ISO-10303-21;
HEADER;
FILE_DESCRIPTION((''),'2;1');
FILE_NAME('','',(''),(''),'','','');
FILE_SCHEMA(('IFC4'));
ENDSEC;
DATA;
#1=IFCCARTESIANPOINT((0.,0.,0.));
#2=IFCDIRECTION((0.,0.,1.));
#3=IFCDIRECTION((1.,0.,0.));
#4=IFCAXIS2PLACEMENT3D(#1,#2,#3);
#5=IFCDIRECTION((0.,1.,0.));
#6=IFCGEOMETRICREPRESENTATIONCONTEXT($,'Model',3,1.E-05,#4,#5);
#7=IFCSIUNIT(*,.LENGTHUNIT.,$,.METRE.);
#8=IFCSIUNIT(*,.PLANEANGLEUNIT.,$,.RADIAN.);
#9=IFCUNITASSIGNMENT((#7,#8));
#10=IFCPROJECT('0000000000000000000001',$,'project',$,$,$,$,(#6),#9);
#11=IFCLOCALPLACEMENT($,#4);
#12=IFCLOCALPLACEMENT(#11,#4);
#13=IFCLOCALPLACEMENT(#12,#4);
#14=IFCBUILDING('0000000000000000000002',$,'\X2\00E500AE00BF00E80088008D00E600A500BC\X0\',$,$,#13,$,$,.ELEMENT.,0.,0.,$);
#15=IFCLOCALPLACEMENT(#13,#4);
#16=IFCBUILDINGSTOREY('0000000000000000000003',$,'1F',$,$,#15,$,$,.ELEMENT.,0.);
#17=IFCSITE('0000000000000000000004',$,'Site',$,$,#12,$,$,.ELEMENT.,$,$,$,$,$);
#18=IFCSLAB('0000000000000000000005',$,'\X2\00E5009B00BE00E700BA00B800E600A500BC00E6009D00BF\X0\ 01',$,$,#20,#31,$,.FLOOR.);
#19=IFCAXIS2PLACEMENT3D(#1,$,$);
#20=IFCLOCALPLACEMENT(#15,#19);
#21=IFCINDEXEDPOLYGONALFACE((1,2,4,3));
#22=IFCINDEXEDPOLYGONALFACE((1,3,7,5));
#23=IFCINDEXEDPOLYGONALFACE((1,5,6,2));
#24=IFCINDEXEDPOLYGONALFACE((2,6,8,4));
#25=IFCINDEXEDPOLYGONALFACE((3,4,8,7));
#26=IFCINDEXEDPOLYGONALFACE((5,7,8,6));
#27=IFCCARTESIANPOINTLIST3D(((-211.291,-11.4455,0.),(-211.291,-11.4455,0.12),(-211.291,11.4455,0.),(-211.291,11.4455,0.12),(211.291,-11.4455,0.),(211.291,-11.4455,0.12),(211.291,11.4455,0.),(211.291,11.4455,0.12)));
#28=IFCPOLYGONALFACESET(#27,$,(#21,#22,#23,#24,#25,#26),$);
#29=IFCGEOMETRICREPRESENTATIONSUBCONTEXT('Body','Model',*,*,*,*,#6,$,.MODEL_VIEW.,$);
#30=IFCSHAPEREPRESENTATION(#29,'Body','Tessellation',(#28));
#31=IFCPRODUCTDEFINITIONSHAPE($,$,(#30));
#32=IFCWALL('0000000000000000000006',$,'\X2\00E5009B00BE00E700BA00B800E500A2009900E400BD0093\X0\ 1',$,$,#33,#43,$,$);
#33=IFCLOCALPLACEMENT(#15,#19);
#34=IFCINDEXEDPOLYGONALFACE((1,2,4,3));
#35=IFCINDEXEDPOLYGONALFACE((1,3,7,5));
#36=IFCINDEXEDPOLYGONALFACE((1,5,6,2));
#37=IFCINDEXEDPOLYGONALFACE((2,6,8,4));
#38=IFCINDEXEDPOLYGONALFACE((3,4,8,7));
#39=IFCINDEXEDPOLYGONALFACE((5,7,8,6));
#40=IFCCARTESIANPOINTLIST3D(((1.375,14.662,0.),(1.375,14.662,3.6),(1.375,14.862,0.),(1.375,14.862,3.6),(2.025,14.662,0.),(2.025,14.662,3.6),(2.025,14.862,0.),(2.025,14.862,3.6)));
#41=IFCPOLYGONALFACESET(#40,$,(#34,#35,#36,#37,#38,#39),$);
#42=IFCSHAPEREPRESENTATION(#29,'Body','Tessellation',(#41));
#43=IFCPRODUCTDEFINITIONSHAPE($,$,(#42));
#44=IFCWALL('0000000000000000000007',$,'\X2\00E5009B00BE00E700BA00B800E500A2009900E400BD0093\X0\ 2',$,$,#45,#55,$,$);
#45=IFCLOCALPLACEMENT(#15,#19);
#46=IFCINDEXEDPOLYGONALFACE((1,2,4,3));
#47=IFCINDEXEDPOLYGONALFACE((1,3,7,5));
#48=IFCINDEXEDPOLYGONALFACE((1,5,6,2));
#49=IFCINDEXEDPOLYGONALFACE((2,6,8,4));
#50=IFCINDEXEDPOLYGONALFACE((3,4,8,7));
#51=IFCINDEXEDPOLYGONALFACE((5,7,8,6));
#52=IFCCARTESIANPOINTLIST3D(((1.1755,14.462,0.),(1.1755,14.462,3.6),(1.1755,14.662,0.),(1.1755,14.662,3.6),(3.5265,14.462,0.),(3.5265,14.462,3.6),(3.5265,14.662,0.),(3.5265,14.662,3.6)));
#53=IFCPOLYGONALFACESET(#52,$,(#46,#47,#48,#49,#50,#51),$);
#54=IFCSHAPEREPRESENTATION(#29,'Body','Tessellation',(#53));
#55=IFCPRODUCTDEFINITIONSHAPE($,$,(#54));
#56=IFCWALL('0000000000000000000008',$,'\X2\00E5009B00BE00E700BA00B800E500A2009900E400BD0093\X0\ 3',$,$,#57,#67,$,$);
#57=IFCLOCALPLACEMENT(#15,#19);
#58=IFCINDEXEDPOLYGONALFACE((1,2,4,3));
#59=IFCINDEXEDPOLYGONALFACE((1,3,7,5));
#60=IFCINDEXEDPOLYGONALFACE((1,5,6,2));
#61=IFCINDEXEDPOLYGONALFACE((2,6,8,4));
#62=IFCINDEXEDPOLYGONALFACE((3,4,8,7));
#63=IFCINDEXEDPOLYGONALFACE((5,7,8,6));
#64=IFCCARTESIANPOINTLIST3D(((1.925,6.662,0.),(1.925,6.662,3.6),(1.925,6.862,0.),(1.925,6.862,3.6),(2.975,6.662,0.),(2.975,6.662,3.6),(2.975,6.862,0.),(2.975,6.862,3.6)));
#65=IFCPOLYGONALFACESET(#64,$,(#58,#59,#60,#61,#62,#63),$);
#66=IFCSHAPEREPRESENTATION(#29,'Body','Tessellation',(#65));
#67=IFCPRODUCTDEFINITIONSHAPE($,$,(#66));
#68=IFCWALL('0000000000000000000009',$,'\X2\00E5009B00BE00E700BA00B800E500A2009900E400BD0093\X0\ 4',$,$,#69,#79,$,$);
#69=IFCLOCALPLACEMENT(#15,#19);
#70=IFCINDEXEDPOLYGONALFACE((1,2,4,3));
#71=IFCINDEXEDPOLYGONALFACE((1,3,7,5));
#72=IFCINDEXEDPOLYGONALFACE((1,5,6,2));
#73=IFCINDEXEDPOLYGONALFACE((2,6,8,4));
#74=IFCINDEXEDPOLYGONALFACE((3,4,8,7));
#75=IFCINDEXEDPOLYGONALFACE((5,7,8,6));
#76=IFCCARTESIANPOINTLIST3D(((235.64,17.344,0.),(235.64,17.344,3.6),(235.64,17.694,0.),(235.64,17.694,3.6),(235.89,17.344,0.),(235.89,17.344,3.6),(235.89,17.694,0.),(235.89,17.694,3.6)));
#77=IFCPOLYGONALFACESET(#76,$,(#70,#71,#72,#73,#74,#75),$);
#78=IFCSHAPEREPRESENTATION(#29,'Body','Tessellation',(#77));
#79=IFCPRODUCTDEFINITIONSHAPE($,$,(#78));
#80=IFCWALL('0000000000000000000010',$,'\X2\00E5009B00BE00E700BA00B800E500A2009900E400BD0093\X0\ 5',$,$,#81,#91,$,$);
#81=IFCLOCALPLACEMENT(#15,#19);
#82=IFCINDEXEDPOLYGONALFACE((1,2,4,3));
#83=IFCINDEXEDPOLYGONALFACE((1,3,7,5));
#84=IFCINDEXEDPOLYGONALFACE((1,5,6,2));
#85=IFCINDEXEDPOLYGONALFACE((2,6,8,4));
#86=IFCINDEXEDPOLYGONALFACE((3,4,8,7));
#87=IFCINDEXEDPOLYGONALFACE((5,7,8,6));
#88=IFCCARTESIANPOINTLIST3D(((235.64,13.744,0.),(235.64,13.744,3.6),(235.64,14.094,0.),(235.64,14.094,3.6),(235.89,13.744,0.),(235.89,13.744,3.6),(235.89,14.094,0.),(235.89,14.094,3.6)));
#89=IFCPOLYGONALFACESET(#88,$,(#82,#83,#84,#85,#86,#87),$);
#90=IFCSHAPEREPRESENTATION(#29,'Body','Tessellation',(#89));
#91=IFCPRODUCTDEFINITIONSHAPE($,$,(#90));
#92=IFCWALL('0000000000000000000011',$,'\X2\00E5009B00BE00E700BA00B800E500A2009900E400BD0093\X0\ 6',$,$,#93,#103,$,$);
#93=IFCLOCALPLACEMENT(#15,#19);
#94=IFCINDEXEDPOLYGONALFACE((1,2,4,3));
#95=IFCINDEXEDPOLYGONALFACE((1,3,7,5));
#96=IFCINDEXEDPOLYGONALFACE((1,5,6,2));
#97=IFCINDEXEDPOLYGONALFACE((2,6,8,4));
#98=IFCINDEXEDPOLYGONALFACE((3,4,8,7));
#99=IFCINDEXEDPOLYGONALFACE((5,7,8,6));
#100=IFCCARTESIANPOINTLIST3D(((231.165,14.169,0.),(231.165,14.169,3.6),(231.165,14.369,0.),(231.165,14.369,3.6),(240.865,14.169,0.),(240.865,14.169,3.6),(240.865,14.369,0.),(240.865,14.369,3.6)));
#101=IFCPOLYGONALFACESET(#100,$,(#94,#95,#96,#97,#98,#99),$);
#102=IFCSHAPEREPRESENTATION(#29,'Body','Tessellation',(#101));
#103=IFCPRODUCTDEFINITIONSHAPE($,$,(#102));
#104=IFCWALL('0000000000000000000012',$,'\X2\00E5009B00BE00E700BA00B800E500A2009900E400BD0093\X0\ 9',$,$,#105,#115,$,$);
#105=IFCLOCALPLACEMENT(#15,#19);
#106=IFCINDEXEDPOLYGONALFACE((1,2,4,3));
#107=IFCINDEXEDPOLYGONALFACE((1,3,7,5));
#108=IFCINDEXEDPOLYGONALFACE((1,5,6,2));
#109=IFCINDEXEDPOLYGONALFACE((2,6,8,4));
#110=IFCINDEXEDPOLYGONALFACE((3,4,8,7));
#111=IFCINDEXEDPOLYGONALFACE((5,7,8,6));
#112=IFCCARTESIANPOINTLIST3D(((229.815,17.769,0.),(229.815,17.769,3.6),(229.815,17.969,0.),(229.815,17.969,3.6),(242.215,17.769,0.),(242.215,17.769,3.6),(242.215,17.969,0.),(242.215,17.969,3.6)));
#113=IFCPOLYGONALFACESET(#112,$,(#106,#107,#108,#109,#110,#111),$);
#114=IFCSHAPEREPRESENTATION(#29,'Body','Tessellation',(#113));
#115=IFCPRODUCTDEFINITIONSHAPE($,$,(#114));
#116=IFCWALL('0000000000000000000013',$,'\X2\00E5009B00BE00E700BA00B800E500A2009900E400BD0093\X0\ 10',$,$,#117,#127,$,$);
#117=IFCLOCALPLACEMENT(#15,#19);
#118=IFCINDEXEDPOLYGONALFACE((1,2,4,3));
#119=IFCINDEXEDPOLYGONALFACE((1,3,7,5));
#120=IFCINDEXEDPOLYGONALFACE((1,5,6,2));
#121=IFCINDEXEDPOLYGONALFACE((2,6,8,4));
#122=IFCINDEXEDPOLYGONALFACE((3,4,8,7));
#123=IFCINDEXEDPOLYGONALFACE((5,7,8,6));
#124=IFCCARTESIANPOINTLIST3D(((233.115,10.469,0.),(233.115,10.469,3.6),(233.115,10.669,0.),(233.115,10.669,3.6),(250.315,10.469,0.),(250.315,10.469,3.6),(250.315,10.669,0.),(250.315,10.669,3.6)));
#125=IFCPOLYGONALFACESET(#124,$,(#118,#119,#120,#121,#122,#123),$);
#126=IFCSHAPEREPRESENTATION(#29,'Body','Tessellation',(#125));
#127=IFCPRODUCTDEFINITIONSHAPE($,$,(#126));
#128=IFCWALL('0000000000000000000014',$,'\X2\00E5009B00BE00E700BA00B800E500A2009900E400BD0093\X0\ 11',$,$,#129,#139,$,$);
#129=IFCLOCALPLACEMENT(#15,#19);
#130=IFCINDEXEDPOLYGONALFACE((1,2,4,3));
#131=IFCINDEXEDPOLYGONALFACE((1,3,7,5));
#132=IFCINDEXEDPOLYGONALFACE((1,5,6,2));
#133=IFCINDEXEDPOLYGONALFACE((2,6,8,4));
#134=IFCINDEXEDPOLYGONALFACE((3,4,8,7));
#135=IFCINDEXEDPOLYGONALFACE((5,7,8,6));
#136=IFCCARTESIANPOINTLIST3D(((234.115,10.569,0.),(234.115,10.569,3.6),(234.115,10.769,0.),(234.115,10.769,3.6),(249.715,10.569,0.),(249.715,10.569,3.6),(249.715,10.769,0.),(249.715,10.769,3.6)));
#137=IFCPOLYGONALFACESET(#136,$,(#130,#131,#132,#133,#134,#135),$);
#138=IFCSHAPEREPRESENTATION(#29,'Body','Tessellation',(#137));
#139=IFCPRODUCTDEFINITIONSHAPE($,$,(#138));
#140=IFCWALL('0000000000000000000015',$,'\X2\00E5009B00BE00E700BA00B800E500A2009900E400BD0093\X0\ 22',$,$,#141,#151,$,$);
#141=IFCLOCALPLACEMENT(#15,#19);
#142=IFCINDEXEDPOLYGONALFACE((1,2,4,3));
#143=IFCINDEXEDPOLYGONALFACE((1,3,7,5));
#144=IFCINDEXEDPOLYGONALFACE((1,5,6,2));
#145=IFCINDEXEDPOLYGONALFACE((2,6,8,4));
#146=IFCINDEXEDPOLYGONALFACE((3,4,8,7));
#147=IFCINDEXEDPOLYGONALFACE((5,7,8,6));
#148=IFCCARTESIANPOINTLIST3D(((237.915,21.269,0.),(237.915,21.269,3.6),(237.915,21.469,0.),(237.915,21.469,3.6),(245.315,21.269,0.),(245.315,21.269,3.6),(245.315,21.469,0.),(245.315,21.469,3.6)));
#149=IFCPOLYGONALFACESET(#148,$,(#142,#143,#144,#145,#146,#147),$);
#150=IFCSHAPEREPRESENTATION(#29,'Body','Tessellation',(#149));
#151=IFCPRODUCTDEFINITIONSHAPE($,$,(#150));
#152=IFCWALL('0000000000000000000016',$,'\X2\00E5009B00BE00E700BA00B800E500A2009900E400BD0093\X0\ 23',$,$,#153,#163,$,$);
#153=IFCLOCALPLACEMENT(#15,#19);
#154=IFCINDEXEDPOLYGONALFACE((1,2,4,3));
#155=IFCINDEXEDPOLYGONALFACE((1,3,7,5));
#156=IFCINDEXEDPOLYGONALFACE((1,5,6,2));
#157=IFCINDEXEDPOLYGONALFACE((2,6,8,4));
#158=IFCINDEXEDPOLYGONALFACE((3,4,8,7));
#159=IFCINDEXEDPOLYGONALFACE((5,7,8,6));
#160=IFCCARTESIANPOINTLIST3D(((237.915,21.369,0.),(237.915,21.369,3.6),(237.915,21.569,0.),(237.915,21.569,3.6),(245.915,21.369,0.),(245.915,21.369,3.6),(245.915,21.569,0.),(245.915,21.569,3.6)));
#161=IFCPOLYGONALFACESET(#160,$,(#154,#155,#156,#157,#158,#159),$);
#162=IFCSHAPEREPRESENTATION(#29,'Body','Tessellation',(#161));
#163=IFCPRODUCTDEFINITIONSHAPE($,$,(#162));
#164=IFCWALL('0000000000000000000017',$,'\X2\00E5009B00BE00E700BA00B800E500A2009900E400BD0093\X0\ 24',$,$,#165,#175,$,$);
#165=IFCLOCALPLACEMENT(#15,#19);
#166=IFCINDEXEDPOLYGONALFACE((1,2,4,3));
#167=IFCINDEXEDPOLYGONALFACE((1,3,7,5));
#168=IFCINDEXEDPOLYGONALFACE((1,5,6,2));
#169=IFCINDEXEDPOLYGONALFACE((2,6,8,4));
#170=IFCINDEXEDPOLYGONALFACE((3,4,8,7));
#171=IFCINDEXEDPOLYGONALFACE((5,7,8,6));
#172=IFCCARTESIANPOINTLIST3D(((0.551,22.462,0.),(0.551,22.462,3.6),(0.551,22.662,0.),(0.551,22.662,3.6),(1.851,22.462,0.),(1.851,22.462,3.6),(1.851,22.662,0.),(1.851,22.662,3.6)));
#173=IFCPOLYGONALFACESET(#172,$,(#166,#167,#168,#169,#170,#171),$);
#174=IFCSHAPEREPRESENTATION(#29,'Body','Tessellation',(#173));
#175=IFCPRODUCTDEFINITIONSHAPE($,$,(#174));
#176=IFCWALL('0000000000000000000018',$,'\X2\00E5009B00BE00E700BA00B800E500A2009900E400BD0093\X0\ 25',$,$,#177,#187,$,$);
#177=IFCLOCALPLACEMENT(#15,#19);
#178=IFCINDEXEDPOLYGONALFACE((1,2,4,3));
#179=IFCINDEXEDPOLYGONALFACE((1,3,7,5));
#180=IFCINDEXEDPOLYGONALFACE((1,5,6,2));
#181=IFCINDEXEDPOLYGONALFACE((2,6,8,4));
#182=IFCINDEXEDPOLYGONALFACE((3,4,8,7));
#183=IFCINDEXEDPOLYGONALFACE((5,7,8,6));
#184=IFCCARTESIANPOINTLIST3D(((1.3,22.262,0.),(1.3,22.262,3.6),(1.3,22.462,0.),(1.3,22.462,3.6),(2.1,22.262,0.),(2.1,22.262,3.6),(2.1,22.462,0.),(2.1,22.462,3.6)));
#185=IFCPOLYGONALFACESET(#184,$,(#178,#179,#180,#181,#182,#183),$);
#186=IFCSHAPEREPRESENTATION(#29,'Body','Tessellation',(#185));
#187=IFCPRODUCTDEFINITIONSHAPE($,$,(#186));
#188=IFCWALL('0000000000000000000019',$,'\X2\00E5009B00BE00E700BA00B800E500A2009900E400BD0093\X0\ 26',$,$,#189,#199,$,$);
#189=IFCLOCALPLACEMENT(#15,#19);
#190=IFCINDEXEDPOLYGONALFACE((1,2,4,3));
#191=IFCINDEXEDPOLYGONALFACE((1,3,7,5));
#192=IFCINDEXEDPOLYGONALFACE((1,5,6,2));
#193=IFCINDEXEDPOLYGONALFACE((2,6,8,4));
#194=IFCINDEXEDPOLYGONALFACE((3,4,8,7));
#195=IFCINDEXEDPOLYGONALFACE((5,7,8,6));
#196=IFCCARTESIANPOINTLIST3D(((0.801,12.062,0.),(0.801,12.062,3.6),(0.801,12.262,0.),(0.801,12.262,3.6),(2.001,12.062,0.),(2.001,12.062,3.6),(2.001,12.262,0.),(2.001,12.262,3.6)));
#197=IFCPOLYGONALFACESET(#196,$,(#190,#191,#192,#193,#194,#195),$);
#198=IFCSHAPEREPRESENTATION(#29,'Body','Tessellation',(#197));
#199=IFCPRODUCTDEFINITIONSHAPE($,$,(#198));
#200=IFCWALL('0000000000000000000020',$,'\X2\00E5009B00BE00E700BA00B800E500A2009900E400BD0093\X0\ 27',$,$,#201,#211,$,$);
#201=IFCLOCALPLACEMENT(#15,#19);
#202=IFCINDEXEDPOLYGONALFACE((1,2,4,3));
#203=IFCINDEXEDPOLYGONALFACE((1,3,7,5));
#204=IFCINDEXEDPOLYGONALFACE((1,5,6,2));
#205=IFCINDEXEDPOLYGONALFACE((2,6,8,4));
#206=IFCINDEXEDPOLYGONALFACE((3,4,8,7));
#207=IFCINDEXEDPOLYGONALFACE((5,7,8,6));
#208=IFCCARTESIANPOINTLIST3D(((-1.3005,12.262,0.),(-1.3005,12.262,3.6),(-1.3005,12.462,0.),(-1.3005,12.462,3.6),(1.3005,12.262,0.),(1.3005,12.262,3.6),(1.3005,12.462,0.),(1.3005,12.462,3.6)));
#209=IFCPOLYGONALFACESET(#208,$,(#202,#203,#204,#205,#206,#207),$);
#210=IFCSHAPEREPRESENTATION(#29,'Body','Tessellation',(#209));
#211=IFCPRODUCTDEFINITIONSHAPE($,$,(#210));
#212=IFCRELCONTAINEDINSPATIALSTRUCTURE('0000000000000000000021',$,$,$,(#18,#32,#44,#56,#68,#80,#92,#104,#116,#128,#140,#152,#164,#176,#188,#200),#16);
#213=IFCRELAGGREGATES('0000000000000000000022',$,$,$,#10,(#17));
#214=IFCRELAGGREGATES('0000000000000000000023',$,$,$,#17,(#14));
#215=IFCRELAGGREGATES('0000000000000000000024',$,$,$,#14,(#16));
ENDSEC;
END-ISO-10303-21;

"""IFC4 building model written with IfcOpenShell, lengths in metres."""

from ifc_helpers import new_model, si_unit, direction, frame, frame_2d, origin_with_axes, place, context, subcontext, project, spatial, rectangle, extrude, element, save


model = new_model("IFC4")

# Units and contexts
model_context = context("Model", 3, precision=1e-05, world=origin_with_axes(), true_north=direction((0.0, 1.0, 0.0)))
body_context = subcontext(model_context, "Body", "Model", "MODEL_VIEW")
ifc_project = project(units=[si_unit("LENGTHUNIT", "METRE"), si_unit("PLANEANGLEUNIT", "RADIAN")], contexts=[model_context])

# Site, building, storey
placement = place(None, origin_with_axes())
site_placement = place(placement, origin_with_axes())
site = spatial("IfcSite", under=ifc_project, at=site_placement, Name="Site", CompositionType="ELEMENT")
building_placement = place(site_placement, origin_with_axes())
building = spatial("IfcBuilding", under=site, at=building_placement, Name="å®¿è\u0088\u008dæ¥¼", CompositionType="ELEMENT", ElevationOfRefHeight=0.0, ElevationOfTerrain=0.0)
storey_placement = place(building_placement, origin_with_axes())
storey = spatial("IfcBuildingStorey", under=building, at=storey_placement, Name="1F", CompositionType="ELEMENT", Elevation=0.0)

# Slab
slab_placement = place(storey_placement, origin_with_axes())
element("IfcSlab", 1, at=slab_placement, inside=storey, Name="å\u009b¾çº¸æ¥¼æ\u009d¿ 01", PredefinedType="FLOOR", context=body_context, shape_type="SweptSolid", body=[
    extrude(rectangle(XDim=422.582, YDim=22.891, at=frame_2d((0.0, 0.0), x_axis=(1.0, 0.0, 0.0))), frame((0.0, 0.0, 0.0), z_axis=(0.0, 0.0, 1.0)), (0.0, 0.0, 1.0), 0.12),
])

# Walls
wall_1_placement = place(storey_placement, frame((1.7, 14.762, 0.0), z_axis=(0.0, 0.0, 1.0), x_axis=(1.0, 0.0, 0.0)))
element("IfcWall", 2, at=wall_1_placement, inside=storey, Name="å\u009b¾çº¸å¢\u0099ä½\u0093 1", context=body_context, shape_type="SweptSolid", body=[
    extrude(rectangle(XDim=0.65, YDim=0.2, at=frame_2d((0.0, 0.0), x_axis=(1.0, 0.0, 0.0))), frame((0.0, 0.0, 0.0), z_axis=(0.0, 0.0, 1.0)), (0.0, 0.0, 1.0), 3.6),
])
wall_2_placement = place(storey_placement, frame((2.351, 14.562, 0.0), z_axis=(0.0, 0.0, 1.0), x_axis=(-1.0, 0.0, 0.0)))
element("IfcWall", 3, at=wall_2_placement, inside=storey, Name="å\u009b¾çº¸å¢\u0099ä½\u0093 2", context=body_context, shape_type="SweptSolid", body=[
    extrude(rectangle(XDim=2.351, YDim=0.2, at=frame_2d((0.0, 0.0), x_axis=(1.0, 0.0, 0.0))), frame((0.0, 0.0, 0.0), z_axis=(0.0, 0.0, 1.0)), (0.0, 0.0, 1.0), 3.6),
])
wall_3_placement = place(storey_placement, frame((2.45, 6.762, 0.0), z_axis=(0.0, 0.0, 1.0), x_axis=(-1.0, 0.0, 0.0)))
element("IfcWall", 4, at=wall_3_placement, inside=storey, Name="å\u009b¾çº¸å¢\u0099ä½\u0093 3", context=body_context, shape_type="SweptSolid", body=[
    extrude(rectangle(XDim=1.05, YDim=0.2, at=frame_2d((0.0, 0.0), x_axis=(1.0, 0.0, 0.0))), frame((0.0, 0.0, 0.0), z_axis=(0.0, 0.0, 1.0)), (0.0, 0.0, 1.0), 3.6),
])
for number, where, z_axis, x_axis, name in (
    (5, (235.765, 17.519, 0.0), (0.0, 0.0, 1.0), (1.0, 0.0, 0.0), "å\u009b¾çº¸å¢\u0099ä½\u0093 4"),
    (6, (235.765, 13.919, 0.0), (0.0, 0.0, 1.0), (1.0, 0.0, 0.0), "å\u009b¾çº¸å¢\u0099ä½\u0093 5"),
):
    element("IfcWall", number, at=place(storey_placement, frame(where, z_axis=z_axis, x_axis=x_axis)), inside=storey, Name=name, context=body_context, shape_type="SweptSolid", body=[
        extrude(rectangle(XDim=0.25, YDim=0.35, at=frame_2d((0.0, 0.0), x_axis=(1.0, 0.0, 0.0))), frame((0.0, 0.0, 0.0), z_axis=(0.0, 0.0, 1.0)), (0.0, 0.0, 1.0), 3.6),
    ])
wall_4_placement = place(storey_placement, frame((236.015, 14.269, 0.0), z_axis=(0.0, 0.0, 1.0), x_axis=(-1.0, 0.0, 0.0)))
element("IfcWall", 7, at=wall_4_placement, inside=storey, Name="å\u009b¾çº¸å¢\u0099ä½\u0093 6", context=body_context, shape_type="SweptSolid", body=[
    extrude(rectangle(XDim=9.7, YDim=0.2, at=frame_2d((0.0, 0.0), x_axis=(1.0, 0.0, 0.0))), frame((0.0, 0.0, 0.0), z_axis=(0.0, 0.0, 1.0)), (0.0, 0.0, 1.0), 3.6),
])
wall_5_placement = place(storey_placement, frame((236.015, 17.869, 0.0), z_axis=(0.0, 0.0, 1.0), x_axis=(-1.0, 0.0, 0.0)))
element("IfcWall", 8, at=wall_5_placement, inside=storey, Name="å\u009b¾çº¸å¢\u0099ä½\u0093 9", context=body_context, shape_type="SweptSolid", body=[
    extrude(rectangle(XDim=12.4, YDim=0.2, at=frame_2d((0.0, 0.0), x_axis=(1.0, 0.0, 0.0))), frame((0.0, 0.0, 0.0), z_axis=(0.0, 0.0, 1.0)), (0.0, 0.0, 1.0), 3.6),
])
wall_6_placement = place(storey_placement, frame((241.715, 10.569, 0.0), z_axis=(0.0, 0.0, 1.0), x_axis=(-1.0, 0.0, 0.0)))
element("IfcWall", 9, at=wall_6_placement, inside=storey, Name="å\u009b¾çº¸å¢\u0099ä½\u0093 10", context=body_context, shape_type="SweptSolid", body=[
    extrude(rectangle(XDim=17.2, YDim=0.2, at=frame_2d((0.0, 0.0), x_axis=(1.0, 0.0, 0.0))), frame((0.0, 0.0, 0.0), z_axis=(0.0, 0.0, 1.0)), (0.0, 0.0, 1.0), 3.6),
])
wall_7_placement = place(storey_placement, frame((241.915, 10.669, 0.0), z_axis=(0.0, 0.0, 1.0), x_axis=(-1.0, 0.0, 0.0)))
element("IfcWall", 10, at=wall_7_placement, inside=storey, Name="å\u009b¾çº¸å¢\u0099ä½\u0093 11", context=body_context, shape_type="SweptSolid", body=[
    extrude(rectangle(XDim=15.6, YDim=0.2, at=frame_2d((0.0, 0.0), x_axis=(1.0, 0.0, 0.0))), frame((0.0, 0.0, 0.0), z_axis=(0.0, 0.0, 1.0)), (0.0, 0.0, 1.0), 3.6),
])
wall_8_placement = place(storey_placement, frame((241.615, 21.369, 0.0), z_axis=(0.0, 0.0, 1.0), x_axis=(-1.0, 0.0, 0.0)))
element("IfcWall", 11, at=wall_8_placement, inside=storey, Name="å\u009b¾çº¸å¢\u0099ä½\u0093 22", context=body_context, shape_type="SweptSolid", body=[
    extrude(rectangle(XDim=7.4, YDim=0.2, at=frame_2d((0.0, 0.0), x_axis=(1.0, 0.0, 0.0))), frame((0.0, 0.0, 0.0), z_axis=(0.0, 0.0, 1.0)), (0.0, 0.0, 1.0), 3.6),
])
wall_9_placement = place(storey_placement, frame((241.915, 21.469, 0.0), z_axis=(0.0, 0.0, 1.0), x_axis=(-1.0, 0.0, 0.0)))
element("IfcWall", 12, at=wall_9_placement, inside=storey, Name="å\u009b¾çº¸å¢\u0099ä½\u0093 23", context=body_context, shape_type="SweptSolid", body=[
    extrude(rectangle(XDim=8.0, YDim=0.2, at=frame_2d((0.0, 0.0), x_axis=(1.0, 0.0, 0.0))), frame((0.0, 0.0, 0.0), z_axis=(0.0, 0.0, 1.0)), (0.0, 0.0, 1.0), 3.6),
])
wall_10_placement = place(storey_placement, frame((1.201, 22.562, 0.0), z_axis=(0.0, 0.0, 1.0), x_axis=(1.0, 0.0, 0.0)))
element("IfcWall", 13, at=wall_10_placement, inside=storey, Name="å\u009b¾çº¸å¢\u0099ä½\u0093 24", context=body_context, shape_type="SweptSolid", body=[
    extrude(rectangle(XDim=1.3, YDim=0.2, at=frame_2d((0.0, 0.0), x_axis=(1.0, 0.0, 0.0))), frame((0.0, 0.0, 0.0), z_axis=(0.0, 0.0, 1.0)), (0.0, 0.0, 1.0), 3.6),
])
wall_11_placement = place(storey_placement, frame((1.7, 22.362, 0.0), z_axis=(0.0, 0.0, 1.0), x_axis=(1.0, 0.0, 0.0)))
element("IfcWall", 14, at=wall_11_placement, inside=storey, Name="å\u009b¾çº¸å¢\u0099ä½\u0093 25", context=body_context, shape_type="SweptSolid", body=[
    extrude(rectangle(XDim=0.8, YDim=0.2, at=frame_2d((0.0, 0.0), x_axis=(1.0, 0.0, 0.0))), frame((0.0, 0.0, 0.0), z_axis=(0.0, 0.0, 1.0)), (0.0, 0.0, 1.0), 3.6),
])
wall_12_placement = place(storey_placement, frame((1.401, 12.162, 0.0), z_axis=(0.0, 0.0, 1.0), x_axis=(1.0, 0.0, 0.0)))
element("IfcWall", 15, at=wall_12_placement, inside=storey, Name="å\u009b¾çº¸å¢\u0099ä½\u0093 26", context=body_context, shape_type="SweptSolid", body=[
    extrude(rectangle(XDim=1.2, YDim=0.2, at=frame_2d((0.0, 0.0), x_axis=(1.0, 0.0, 0.0))), frame((0.0, 0.0, 0.0), z_axis=(0.0, 0.0, 1.0)), (0.0, 0.0, 1.0), 3.6),
])
wall_13_placement = place(storey_placement, frame((0.0, 12.362, 0.0), z_axis=(0.0, 0.0, 1.0), x_axis=(1.0, 0.0, 0.0)))
element("IfcWall", 16, at=wall_13_placement, inside=storey, Name="å\u009b¾çº¸å¢\u0099ä½\u0093 27", context=body_context, shape_type="SweptSolid", body=[
    extrude(rectangle(XDim=2.601, YDim=0.2, at=frame_2d((0.0, 0.0), x_axis=(1.0, 0.0, 0.0))), frame((0.0, 0.0, 0.0), z_axis=(0.0, 0.0, 1.0)), (0.0, 0.0, 1.0), 3.6),
])

save(model, "model.ifc")
